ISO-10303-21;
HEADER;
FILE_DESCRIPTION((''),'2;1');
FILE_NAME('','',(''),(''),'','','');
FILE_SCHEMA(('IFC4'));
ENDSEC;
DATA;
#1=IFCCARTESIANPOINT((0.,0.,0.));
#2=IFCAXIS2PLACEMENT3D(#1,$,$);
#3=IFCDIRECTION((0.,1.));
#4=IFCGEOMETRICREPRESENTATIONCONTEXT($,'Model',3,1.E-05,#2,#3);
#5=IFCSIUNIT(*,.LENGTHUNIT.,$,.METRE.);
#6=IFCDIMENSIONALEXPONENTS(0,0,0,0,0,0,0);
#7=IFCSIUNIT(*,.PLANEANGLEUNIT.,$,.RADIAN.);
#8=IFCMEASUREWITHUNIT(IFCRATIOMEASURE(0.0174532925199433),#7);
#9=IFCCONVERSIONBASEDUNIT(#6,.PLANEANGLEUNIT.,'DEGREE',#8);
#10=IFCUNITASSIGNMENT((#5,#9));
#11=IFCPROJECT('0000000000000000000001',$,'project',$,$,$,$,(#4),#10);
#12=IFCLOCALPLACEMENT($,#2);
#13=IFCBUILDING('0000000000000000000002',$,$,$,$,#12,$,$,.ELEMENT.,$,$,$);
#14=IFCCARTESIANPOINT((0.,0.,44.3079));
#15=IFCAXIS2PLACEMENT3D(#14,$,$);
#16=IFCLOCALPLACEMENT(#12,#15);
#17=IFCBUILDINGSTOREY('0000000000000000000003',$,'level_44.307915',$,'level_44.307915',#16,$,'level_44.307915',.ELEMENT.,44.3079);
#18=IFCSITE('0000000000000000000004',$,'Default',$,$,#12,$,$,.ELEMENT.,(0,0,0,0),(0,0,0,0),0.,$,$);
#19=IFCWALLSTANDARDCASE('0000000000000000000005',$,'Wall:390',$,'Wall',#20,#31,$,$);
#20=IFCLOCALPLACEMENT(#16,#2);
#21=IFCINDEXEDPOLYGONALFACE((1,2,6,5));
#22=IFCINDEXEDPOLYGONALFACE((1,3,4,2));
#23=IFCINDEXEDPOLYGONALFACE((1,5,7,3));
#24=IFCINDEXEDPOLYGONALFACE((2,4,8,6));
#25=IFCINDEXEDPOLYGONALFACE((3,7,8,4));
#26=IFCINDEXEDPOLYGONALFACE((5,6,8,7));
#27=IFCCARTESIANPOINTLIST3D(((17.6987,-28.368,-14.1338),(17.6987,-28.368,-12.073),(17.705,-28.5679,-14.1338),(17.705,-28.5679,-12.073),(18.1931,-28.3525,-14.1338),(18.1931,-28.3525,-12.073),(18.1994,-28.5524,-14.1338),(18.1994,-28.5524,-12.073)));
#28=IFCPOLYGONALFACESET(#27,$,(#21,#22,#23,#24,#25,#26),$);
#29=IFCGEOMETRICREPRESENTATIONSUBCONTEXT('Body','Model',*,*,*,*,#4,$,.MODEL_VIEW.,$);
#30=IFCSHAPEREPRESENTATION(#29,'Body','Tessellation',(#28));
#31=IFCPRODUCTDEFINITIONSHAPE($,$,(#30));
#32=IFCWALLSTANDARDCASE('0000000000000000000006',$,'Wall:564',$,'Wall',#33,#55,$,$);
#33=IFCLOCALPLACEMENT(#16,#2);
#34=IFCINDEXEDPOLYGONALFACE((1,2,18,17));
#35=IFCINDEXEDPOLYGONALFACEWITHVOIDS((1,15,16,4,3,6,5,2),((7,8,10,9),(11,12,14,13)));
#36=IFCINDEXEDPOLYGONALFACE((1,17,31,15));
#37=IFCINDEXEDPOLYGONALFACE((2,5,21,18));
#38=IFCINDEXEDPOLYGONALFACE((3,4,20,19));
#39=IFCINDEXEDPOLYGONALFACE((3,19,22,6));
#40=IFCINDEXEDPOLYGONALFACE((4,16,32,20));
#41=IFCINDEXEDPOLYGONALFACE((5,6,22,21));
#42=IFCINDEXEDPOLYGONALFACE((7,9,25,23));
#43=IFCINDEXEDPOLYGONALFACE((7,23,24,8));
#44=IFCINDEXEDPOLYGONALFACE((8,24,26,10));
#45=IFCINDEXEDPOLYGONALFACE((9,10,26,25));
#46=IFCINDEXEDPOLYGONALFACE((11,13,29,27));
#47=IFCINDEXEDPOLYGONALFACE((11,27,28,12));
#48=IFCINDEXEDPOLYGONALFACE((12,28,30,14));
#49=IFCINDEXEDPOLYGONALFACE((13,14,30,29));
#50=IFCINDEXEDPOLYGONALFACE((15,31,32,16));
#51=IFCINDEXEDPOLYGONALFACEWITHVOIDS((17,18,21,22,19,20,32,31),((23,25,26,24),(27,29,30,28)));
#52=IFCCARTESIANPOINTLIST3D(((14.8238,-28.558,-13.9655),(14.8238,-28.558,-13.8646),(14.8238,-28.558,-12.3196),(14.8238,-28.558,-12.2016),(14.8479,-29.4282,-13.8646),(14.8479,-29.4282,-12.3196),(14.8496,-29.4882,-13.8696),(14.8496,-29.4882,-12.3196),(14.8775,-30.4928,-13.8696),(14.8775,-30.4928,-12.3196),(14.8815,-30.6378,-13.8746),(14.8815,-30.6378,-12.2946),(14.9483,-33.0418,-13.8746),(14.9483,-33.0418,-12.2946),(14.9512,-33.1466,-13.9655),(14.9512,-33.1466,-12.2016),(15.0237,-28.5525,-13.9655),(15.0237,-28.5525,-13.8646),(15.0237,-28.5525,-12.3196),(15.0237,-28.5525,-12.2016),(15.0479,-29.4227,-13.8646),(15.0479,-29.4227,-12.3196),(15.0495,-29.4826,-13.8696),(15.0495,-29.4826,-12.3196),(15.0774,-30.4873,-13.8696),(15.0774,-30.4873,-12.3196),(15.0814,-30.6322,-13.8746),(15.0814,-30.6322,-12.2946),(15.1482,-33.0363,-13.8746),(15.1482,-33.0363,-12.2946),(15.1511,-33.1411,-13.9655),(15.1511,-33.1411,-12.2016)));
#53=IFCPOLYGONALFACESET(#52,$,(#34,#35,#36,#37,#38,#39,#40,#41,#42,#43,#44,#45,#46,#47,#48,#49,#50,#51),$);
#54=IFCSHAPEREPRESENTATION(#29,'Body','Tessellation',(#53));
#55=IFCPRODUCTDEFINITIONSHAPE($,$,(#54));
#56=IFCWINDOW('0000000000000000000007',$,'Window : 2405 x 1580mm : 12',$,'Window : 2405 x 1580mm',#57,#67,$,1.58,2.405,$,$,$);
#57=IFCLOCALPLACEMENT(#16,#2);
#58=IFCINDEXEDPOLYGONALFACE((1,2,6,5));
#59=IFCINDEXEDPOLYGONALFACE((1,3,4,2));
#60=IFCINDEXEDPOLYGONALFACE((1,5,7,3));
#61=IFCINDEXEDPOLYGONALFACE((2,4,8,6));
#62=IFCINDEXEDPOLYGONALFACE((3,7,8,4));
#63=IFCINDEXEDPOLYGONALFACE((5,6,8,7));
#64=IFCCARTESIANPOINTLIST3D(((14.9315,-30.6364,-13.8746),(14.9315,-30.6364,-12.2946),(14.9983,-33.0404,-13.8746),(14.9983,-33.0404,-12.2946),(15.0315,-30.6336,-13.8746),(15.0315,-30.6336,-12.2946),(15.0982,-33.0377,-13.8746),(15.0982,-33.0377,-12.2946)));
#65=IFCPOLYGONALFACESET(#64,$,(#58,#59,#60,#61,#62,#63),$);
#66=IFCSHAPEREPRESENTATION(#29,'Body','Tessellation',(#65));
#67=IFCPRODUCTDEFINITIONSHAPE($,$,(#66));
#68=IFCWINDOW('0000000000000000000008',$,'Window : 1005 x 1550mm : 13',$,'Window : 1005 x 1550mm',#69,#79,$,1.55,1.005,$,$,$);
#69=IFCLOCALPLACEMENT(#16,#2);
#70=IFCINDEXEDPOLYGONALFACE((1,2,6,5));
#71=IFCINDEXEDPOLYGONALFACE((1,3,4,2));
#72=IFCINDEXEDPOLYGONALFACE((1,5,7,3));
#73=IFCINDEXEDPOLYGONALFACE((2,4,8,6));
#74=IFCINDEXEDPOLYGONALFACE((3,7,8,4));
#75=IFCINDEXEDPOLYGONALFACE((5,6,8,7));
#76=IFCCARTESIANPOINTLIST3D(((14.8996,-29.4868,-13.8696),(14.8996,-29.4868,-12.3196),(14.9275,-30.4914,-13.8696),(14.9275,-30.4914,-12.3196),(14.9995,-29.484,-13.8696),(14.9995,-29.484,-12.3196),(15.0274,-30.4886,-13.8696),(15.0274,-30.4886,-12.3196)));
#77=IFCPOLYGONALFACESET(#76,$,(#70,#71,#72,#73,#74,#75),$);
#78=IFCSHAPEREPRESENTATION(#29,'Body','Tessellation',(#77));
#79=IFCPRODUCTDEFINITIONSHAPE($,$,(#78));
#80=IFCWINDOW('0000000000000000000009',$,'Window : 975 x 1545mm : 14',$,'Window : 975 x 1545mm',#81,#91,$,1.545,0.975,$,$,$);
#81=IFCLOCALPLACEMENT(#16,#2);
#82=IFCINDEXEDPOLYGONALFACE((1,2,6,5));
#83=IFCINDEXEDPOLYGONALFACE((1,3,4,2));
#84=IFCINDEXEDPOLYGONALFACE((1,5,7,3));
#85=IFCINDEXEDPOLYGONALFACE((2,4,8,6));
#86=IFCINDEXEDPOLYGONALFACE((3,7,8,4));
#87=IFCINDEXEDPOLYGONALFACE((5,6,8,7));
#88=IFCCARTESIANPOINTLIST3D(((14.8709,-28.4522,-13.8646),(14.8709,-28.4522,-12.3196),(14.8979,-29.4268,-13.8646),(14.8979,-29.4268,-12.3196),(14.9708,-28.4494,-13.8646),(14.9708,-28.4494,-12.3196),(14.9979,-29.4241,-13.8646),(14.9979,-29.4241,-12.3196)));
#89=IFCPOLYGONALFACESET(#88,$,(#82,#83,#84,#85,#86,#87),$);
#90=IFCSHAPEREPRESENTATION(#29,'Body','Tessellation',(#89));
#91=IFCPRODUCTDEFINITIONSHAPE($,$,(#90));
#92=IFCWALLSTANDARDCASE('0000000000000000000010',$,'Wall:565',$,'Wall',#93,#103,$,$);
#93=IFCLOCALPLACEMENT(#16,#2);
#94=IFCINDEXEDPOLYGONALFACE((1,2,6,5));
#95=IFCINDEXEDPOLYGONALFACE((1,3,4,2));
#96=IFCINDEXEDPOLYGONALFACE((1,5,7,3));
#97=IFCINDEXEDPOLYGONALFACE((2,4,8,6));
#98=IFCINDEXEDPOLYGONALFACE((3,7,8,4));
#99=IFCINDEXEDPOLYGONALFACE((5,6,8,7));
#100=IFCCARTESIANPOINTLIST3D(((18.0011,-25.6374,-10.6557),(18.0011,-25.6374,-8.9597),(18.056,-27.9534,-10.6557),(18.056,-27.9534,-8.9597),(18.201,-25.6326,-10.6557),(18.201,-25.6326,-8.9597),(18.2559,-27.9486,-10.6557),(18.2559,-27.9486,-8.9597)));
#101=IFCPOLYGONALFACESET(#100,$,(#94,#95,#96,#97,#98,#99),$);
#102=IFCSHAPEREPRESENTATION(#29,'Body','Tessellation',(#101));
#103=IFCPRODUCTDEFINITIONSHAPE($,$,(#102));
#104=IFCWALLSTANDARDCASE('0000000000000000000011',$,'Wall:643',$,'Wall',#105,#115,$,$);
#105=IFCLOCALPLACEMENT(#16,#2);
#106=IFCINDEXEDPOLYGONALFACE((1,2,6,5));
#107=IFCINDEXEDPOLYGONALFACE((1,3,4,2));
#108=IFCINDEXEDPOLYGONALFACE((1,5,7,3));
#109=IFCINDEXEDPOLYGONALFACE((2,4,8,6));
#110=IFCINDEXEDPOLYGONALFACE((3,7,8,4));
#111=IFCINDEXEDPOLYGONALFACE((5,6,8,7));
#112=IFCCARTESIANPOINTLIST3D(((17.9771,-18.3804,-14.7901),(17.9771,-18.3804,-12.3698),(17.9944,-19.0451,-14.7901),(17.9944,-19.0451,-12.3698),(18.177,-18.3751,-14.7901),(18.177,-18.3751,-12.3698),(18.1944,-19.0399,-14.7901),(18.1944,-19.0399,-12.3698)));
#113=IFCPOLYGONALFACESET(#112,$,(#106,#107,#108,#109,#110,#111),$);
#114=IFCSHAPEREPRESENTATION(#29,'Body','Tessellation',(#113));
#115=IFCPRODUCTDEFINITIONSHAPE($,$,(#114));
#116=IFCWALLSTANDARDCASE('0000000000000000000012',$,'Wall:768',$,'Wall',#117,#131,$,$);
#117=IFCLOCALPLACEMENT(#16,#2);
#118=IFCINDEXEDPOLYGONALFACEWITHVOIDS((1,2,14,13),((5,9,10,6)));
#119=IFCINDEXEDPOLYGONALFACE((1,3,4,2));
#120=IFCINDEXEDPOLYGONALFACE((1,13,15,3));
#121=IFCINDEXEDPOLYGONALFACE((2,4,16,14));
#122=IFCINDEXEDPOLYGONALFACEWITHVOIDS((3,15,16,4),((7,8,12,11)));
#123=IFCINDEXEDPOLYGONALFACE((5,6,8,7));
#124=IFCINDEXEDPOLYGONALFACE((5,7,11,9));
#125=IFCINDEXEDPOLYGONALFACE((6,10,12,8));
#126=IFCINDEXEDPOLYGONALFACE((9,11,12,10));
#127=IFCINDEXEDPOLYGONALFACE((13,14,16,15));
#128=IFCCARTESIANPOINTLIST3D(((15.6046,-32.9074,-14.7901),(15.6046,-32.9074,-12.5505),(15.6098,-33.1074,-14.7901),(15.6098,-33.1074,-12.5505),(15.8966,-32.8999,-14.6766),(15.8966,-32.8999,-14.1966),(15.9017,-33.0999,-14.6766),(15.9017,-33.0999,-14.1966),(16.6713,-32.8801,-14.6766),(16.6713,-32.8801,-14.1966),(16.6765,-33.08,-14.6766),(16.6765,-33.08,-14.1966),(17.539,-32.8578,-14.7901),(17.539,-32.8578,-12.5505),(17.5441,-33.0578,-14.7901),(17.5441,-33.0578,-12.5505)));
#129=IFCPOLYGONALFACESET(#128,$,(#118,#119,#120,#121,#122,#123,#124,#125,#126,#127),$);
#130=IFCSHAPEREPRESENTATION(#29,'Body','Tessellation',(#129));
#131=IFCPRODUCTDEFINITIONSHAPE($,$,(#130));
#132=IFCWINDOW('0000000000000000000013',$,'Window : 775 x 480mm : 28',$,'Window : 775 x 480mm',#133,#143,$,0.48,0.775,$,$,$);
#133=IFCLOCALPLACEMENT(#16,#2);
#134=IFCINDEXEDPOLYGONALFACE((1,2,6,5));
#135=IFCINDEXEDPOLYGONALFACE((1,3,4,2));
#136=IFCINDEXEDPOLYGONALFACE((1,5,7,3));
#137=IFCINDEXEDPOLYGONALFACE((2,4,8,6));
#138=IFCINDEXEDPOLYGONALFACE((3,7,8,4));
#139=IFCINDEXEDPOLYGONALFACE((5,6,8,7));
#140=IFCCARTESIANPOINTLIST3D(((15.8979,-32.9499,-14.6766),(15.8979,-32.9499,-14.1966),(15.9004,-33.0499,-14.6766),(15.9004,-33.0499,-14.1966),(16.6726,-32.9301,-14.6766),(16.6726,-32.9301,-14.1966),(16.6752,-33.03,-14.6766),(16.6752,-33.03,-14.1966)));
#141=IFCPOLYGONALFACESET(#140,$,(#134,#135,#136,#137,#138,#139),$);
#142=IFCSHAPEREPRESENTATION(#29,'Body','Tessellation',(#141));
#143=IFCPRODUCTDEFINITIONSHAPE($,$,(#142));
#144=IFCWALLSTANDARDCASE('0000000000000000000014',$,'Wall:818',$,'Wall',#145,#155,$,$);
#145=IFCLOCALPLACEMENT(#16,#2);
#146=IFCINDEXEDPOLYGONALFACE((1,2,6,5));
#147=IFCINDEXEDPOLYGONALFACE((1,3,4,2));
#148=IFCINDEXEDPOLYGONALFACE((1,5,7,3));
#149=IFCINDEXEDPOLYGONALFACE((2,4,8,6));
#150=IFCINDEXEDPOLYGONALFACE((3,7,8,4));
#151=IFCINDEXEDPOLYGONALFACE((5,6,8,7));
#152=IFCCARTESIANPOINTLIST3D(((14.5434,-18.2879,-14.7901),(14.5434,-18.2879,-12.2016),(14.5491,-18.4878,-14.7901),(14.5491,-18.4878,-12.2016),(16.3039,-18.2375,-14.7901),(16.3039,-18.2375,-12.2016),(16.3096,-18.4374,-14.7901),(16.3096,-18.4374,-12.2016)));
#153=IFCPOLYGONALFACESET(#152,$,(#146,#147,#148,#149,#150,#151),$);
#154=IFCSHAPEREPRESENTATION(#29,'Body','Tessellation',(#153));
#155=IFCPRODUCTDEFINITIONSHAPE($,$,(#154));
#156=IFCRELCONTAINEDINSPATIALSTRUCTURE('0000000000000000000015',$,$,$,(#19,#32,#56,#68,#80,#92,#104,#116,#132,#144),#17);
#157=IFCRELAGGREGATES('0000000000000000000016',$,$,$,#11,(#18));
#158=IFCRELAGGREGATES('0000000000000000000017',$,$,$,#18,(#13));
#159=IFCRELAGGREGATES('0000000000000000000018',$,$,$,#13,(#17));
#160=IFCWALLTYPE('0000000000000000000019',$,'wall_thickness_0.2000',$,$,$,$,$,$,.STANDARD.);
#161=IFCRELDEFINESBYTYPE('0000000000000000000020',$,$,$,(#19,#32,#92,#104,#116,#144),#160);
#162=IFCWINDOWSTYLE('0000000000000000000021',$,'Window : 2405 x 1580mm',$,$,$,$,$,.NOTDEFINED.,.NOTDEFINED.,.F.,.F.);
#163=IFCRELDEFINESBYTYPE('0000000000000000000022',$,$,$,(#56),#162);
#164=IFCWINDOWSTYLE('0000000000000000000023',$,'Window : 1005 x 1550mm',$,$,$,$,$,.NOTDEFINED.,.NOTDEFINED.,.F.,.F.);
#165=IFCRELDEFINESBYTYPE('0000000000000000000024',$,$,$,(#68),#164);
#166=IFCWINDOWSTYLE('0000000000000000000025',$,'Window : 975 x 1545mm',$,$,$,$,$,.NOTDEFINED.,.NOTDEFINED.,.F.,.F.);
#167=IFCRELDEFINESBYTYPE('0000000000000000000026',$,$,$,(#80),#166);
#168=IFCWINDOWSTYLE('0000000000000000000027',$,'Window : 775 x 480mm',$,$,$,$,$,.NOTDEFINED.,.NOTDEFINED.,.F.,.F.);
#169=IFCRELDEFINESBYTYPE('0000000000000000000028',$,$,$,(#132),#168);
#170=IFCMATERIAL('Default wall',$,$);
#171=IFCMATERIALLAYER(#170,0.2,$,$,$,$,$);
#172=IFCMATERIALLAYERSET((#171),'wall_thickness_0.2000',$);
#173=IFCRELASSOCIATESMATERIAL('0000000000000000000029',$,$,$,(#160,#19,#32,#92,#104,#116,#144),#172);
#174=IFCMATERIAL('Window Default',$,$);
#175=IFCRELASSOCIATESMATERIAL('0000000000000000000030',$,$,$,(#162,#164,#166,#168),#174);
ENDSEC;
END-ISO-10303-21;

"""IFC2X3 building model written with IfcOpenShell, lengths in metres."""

from ifc_helpers import new_model, entity, si_unit, converted_unit, direction, frame, frame_2d, origin, origin_2d_with_axis, place, context, subcontext, project, spatial, polyline, rectangle, outline, extrude, source, transform, mapped, material, layer, layer_set, layer_usage, type_object, type_shapes, element, fill, save


model = new_model("IFC2X3")

# Units and contexts
model_context = context("Model", 3, precision=1e-05, world=origin(), true_north=direction((0.0, 1.0)))
body_context = subcontext(model_context, "Body", "Model", "MODEL_VIEW")
ifc_project = project(units=[si_unit("LENGTHUNIT", "METRE"), converted_unit("PLANEANGLEUNIT", "DEGREE", entity("IfcRatioMeasure", 0.0174532925199433), si_unit("PLANEANGLEUNIT", "RADIAN"), dimensions=[0, 0, 0, 0, 0, 0, 0])], contexts=[model_context])

# Site, building, storey
placement_1 = place(None, origin())
site = spatial("IfcSite", under=ifc_project, at=placement_1, Name="Default", CompositionType="ELEMENT", RefLatitude=(0, 0, 0, 0), RefLongitude=(0, 0, 0, 0), RefElevation=0.0)
building = spatial("IfcBuilding", under=site, at=placement_1, CompositionType="ELEMENT")
storey_placement = place(placement_1, frame((0.0, 0.0, 44.3079)))
storey = spatial("IfcBuildingStorey", under=building, at=storey_placement, Name="level_44.307915", ObjectType="level_44.307915", LongName="level_44.307915", CompositionType="ELEMENT", Elevation=44.3079)

# Wall
ifc_material_1 = material(Name="Default wall")
ifc_layer = layer(ifc_material_1, 0.2)
ifc_layer_set = layer_set([ifc_layer], Name="wall_thickness_0.2000")
ifc_layer_usage = layer_usage(ifc_layer_set, "AXIS2", "POSITIVE", -0.1)
wall_type = type_object("IfcWallType", Name="wall_thickness_0.2000", PredefinedType="STANDARD", material=ifc_layer_set)
placement_2 = place(placement_1, frame((0.0, 0.0, 30.1741)))
wall_1_placement = place(placement_2, frame((17.7018, -28.468, 0.0), z_axis=(0.0, 0.0, 1.0), x_axis=(0.999506, 0.031414, 0.0)))
element("IfcWallStandardCase", 1, at=wall_1_placement, inside=storey, type_object=wall_type, material=ifc_layer_usage, Name="Wall:390", ObjectType="Wall", context=body_context, shape_type="SweptSolid", body=[
    extrude(outline(polyline([(0.4947, -0.1), (0.4947, 0.1), (0.0, 0.1), (0.0, -0.1), (0.4947, -0.1)])), origin(), (0.0, 0.0, 1.0), 2.0608),
])

# Wall, openings, windows
placement_3 = place(placement_1, frame((0.0, 0.0, 30.3424)))
wall_2_placement = place(placement_3, frame((15.0512, -33.1439, 0.0), z_axis=(0.0, 0.0, 1.0), x_axis=(-0.027759, 0.999615, 0.0)))
wall_2 = element("IfcWallStandardCase", 2, at=wall_2_placement, inside=storey, type_object=wall_type, material=ifc_layer_usage, Name="Wall:564", ObjectType="Wall", context=body_context, shape_type="SweptSolid", body=[
    extrude(outline(polyline([(4.5904, -0.1), (4.5904, 0.1), (0.0, 0.1), (0.0, -0.1), (4.5904, -0.1)])), origin(), (0.0, 0.0, 1.0), 1.7639),
])
opening_1_placement = place(wall_2_placement, frame((0.1049, -0.1, 0.0909)))
opening_1 = element("IfcOpeningElement", 3, at=opening_1_placement, cuts=wall_2, ObjectType="Opening", context=body_context, shape_type="SweptSolid", body=[
    extrude(rectangle(XDim=2.405, YDim=1.58, at=frame_2d((0.79, 1.2025), x_axis=(0.0, 1.0))), frame((0.0, 0.0, 0.0), z_axis=(0.0, 1.0, 0.0), x_axis=(0.0, 0.0, 1.0)), (0.0, 0.0, 1.0), 0.2),
])
opening_2_placement = place(wall_2_placement, frame((2.6549, -0.1, 0.0959)))
opening_2 = element("IfcOpeningElement", 4, at=opening_2_placement, cuts=wall_2, ObjectType="Opening", context=body_context, shape_type="SweptSolid", body=[
    extrude(rectangle(XDim=1.005, YDim=1.55, at=frame_2d((0.775, 0.5025), x_axis=(0.0, 1.0))), frame((0.0, 0.0, 0.0), z_axis=(0.0, 1.0, 0.0), x_axis=(0.0, 0.0, 1.0)), (0.0, 0.0, 1.0), 0.2),
])
opening_3_placement = place(wall_2_placement, frame((3.7199, -0.1, 0.1009)))
opening_3 = element("IfcOpeningElement", 5, at=opening_3_placement, cuts=wall_2, ObjectType="Opening", context=body_context, shape_type="SweptSolid", body=[
    extrude(rectangle(XDim=0.975, YDim=1.545, at=frame_2d((0.7725, 0.4875), x_axis=(0.0, 1.0))), frame((0.0, 0.0, 0.0), z_axis=(0.0, 1.0, 0.0), x_axis=(0.0, 0.0, 1.0)), (0.0, 0.0, 1.0), 0.2),
])
ifc_material_2 = material(Name="Window Default")
window_style_1 = type_object("IfcWindowStyle", Name="Window : 2405 x 1580mm", ConstructionType="NOTDEFINED", OperationType="NOTDEFINED", ParameterTakesPrecedence=False, Sizeable=False, material=ifc_material_2)
shared_shape_1 = source(origin(), body_context, "Body", "SweptSolid", [
    extrude(rectangle(XDim=0.1, YDim=2.405, at=origin_2d_with_axis()), frame((1.2025, 0.1, 0.0), z_axis=(0.0, 0.0, 1.0), x_axis=(0.0, 1.0, 0.0)), (0.0, 0.0, 1.0), 1.58),
])
type_shapes(window_style_1, [shared_shape_1])
window_1_placement = place(opening_1_placement, origin())
window_1 = element("IfcWindow", 6, at=window_1_placement, inside=storey, type_object=window_style_1, Name="Window : 2405 x 1580mm : 12", ObjectType="Window : 2405 x 1580mm", OverallHeight=1.58, OverallWidth=2.405, context=body_context, shape_type="MappedRepresentation", body=[
    mapped(shared_shape_1, transform((0.0, 0.0, 0.0), scale=1.0)),
])
fill(opening_1, window_1)
window_style_2 = type_object("IfcWindowStyle", Name="Window : 1005 x 1550mm", ConstructionType="NOTDEFINED", OperationType="NOTDEFINED", ParameterTakesPrecedence=False, Sizeable=False, material=ifc_material_2)
shared_shape_2 = source(origin(), body_context, "Body", "SweptSolid", [
    extrude(rectangle(XDim=0.1, YDim=1.005, at=origin_2d_with_axis()), frame((0.5025, 0.1, 0.0), z_axis=(0.0, 0.0, 1.0), x_axis=(0.0, 1.0, 0.0)), (0.0, 0.0, 1.0), 1.55),
])
type_shapes(window_style_2, [shared_shape_2])
window_2_placement = place(opening_2_placement, origin())
window_2 = element("IfcWindow", 7, at=window_2_placement, inside=storey, type_object=window_style_2, Name="Window : 1005 x 1550mm : 13", ObjectType="Window : 1005 x 1550mm", OverallHeight=1.55, OverallWidth=1.005, context=body_context, shape_type="MappedRepresentation", body=[
    mapped(shared_shape_2, transform((0.0, 0.0, 0.0), scale=1.0)),
])
fill(opening_2, window_2)
window_style_3 = type_object("IfcWindowStyle", Name="Window : 975 x 1545mm", ConstructionType="NOTDEFINED", OperationType="NOTDEFINED", ParameterTakesPrecedence=False, Sizeable=False, material=ifc_material_2)
shared_shape_3 = source(origin(), body_context, "Body", "SweptSolid", [
    extrude(rectangle(XDim=0.1, YDim=0.975, at=origin_2d_with_axis()), frame((0.4875, 0.1, 0.0), z_axis=(0.0, 0.0, 1.0), x_axis=(0.0, 1.0, 0.0)), (0.0, 0.0, 1.0), 1.545),
])
type_shapes(window_style_3, [shared_shape_3])
window_3_placement = place(opening_3_placement, origin())
window_3 = element("IfcWindow", 8, at=window_3_placement, inside=storey, type_object=window_style_3, Name="Window : 975 x 1545mm : 14", ObjectType="Window : 975 x 1545mm", OverallHeight=1.545, OverallWidth=0.975, context=body_context, shape_type="MappedRepresentation", body=[
    mapped(shared_shape_3, transform((0.0, 0.0, 0.0), scale=1.0)),
])
fill(opening_3, window_3)

# Walls
placement_4 = place(placement_1, frame((0.0, 0.0, 33.6522)))
wall_3_placement = place(placement_4, frame((18.156, -27.951, 0.0), z_axis=(0.0, 0.0, 1.0), x_axis=(-0.023703, 0.999719, 0.0)))
element("IfcWallStandardCase", 9, at=wall_3_placement, inside=storey, type_object=wall_type, material=ifc_layer_usage, Name="Wall:565", ObjectType="Wall", context=body_context, shape_type="SweptSolid", body=[
    extrude(outline(polyline([(2.3167, -0.1), (2.3167, 0.1), (0.0, 0.1), (0.0, -0.1), (2.3167, -0.1)])), origin(), (0.0, 0.0, 1.0), 1.696),
])
placement_5 = place(placement_1, frame((0.0, 0.0, 29.5178)))
wall_4_placement = place(placement_5, frame((18.077, -18.3777, 0.0), z_axis=(0.0, 0.0, 1.0), x_axis=(0.026141, -0.999658, 0.0)))
element("IfcWallStandardCase", 10, at=wall_4_placement, inside=storey, type_object=wall_type, material=ifc_layer_usage, Name="Wall:643", ObjectType="Wall", context=body_context, shape_type="SweptSolid", body=[
    extrude(outline(polyline([(0.665, -0.1), (0.665, 0.1), (0.0, 0.1), (0.0, -0.1), (0.665, -0.1)])), origin(), (0.0, 0.0, 1.0), 2.4204),
])

# Wall, opening, window
placement_6 = place(placement_1, frame((0.0, 0.0, 29.5178)))
wall_5_placement = place(placement_6, frame((17.5416, -32.9578, 0.0), z_axis=(0.0, 0.0, 1.0), x_axis=(-0.999672, -0.025628, 0.0)))
wall_5 = element("IfcWallStandardCase", 11, at=wall_5_placement, inside=storey, type_object=wall_type, material=ifc_layer_usage, Name="Wall:768", ObjectType="Wall", context=body_context, shape_type="SweptSolid", body=[
    extrude(outline(polyline([(1.935, -0.1), (1.935, 0.1), (0.0, 0.1), (0.0, -0.1), (1.935, -0.1)])), origin(), (0.0, 0.0, 1.0), 2.2397),
])
opening_4_placement = place(wall_5_placement, frame((0.868, -0.1, 0.1136)))
opening_4 = element("IfcOpeningElement", 12, at=opening_4_placement, cuts=wall_5, ObjectType="Opening", context=body_context, shape_type="SweptSolid", body=[
    extrude(rectangle(XDim=0.775, YDim=0.48, at=frame_2d((0.24, 0.3875), x_axis=(0.0, 1.0))), frame((0.0, 0.0, 0.0), z_axis=(0.0, 1.0, 0.0), x_axis=(0.0, 0.0, 1.0)), (0.0, 0.0, 1.0), 0.2),
])
window_style_4 = type_object("IfcWindowStyle", Name="Window : 775 x 480mm", ConstructionType="NOTDEFINED", OperationType="NOTDEFINED", ParameterTakesPrecedence=False, Sizeable=False, material=ifc_material_2)
shared_shape_4 = source(origin(), body_context, "Body", "SweptSolid", [
    extrude(rectangle(XDim=0.1, YDim=0.775, at=origin_2d_with_axis()), frame((0.3875, 0.1, 0.0), z_axis=(0.0, 0.0, 1.0), x_axis=(0.0, 1.0, 0.0)), (0.0, 0.0, 1.0), 0.48),
])
type_shapes(window_style_4, [shared_shape_4])
window_4_placement = place(opening_4_placement, origin())
window_4 = element("IfcWindow", 13, at=window_4_placement, inside=storey, type_object=window_style_4, Name="Window : 775 x 480mm : 28", ObjectType="Window : 775 x 480mm", OverallHeight=0.48, OverallWidth=0.775, context=body_context, shape_type="MappedRepresentation", body=[
    mapped(shared_shape_4, transform((0.0, 0.0, 0.0), scale=1.0)),
])
fill(opening_4, window_4)

# Wall
placement_7 = place(placement_1, frame((0.0, 0.0, 29.5178)))
wall_6_placement = place(placement_7, frame((16.3067, -18.3375, 0.0), z_axis=(0.0, 0.0, 1.0), x_axis=(-0.999591, -0.028582, 0.0)))
element("IfcWallStandardCase", 14, at=wall_6_placement, inside=storey, type_object=wall_type, material=ifc_layer_usage, Name="Wall:818", ObjectType="Wall", context=body_context, shape_type="SweptSolid", body=[
    extrude(outline(polyline([(1.7612, -0.1), (1.7612, 0.1), (0.0, 0.1), (0.0, -0.1), (1.7612, -0.1)])), origin(), (0.0, 0.0, 1.0), 2.5885),
])

save(model, "model.ifc")
